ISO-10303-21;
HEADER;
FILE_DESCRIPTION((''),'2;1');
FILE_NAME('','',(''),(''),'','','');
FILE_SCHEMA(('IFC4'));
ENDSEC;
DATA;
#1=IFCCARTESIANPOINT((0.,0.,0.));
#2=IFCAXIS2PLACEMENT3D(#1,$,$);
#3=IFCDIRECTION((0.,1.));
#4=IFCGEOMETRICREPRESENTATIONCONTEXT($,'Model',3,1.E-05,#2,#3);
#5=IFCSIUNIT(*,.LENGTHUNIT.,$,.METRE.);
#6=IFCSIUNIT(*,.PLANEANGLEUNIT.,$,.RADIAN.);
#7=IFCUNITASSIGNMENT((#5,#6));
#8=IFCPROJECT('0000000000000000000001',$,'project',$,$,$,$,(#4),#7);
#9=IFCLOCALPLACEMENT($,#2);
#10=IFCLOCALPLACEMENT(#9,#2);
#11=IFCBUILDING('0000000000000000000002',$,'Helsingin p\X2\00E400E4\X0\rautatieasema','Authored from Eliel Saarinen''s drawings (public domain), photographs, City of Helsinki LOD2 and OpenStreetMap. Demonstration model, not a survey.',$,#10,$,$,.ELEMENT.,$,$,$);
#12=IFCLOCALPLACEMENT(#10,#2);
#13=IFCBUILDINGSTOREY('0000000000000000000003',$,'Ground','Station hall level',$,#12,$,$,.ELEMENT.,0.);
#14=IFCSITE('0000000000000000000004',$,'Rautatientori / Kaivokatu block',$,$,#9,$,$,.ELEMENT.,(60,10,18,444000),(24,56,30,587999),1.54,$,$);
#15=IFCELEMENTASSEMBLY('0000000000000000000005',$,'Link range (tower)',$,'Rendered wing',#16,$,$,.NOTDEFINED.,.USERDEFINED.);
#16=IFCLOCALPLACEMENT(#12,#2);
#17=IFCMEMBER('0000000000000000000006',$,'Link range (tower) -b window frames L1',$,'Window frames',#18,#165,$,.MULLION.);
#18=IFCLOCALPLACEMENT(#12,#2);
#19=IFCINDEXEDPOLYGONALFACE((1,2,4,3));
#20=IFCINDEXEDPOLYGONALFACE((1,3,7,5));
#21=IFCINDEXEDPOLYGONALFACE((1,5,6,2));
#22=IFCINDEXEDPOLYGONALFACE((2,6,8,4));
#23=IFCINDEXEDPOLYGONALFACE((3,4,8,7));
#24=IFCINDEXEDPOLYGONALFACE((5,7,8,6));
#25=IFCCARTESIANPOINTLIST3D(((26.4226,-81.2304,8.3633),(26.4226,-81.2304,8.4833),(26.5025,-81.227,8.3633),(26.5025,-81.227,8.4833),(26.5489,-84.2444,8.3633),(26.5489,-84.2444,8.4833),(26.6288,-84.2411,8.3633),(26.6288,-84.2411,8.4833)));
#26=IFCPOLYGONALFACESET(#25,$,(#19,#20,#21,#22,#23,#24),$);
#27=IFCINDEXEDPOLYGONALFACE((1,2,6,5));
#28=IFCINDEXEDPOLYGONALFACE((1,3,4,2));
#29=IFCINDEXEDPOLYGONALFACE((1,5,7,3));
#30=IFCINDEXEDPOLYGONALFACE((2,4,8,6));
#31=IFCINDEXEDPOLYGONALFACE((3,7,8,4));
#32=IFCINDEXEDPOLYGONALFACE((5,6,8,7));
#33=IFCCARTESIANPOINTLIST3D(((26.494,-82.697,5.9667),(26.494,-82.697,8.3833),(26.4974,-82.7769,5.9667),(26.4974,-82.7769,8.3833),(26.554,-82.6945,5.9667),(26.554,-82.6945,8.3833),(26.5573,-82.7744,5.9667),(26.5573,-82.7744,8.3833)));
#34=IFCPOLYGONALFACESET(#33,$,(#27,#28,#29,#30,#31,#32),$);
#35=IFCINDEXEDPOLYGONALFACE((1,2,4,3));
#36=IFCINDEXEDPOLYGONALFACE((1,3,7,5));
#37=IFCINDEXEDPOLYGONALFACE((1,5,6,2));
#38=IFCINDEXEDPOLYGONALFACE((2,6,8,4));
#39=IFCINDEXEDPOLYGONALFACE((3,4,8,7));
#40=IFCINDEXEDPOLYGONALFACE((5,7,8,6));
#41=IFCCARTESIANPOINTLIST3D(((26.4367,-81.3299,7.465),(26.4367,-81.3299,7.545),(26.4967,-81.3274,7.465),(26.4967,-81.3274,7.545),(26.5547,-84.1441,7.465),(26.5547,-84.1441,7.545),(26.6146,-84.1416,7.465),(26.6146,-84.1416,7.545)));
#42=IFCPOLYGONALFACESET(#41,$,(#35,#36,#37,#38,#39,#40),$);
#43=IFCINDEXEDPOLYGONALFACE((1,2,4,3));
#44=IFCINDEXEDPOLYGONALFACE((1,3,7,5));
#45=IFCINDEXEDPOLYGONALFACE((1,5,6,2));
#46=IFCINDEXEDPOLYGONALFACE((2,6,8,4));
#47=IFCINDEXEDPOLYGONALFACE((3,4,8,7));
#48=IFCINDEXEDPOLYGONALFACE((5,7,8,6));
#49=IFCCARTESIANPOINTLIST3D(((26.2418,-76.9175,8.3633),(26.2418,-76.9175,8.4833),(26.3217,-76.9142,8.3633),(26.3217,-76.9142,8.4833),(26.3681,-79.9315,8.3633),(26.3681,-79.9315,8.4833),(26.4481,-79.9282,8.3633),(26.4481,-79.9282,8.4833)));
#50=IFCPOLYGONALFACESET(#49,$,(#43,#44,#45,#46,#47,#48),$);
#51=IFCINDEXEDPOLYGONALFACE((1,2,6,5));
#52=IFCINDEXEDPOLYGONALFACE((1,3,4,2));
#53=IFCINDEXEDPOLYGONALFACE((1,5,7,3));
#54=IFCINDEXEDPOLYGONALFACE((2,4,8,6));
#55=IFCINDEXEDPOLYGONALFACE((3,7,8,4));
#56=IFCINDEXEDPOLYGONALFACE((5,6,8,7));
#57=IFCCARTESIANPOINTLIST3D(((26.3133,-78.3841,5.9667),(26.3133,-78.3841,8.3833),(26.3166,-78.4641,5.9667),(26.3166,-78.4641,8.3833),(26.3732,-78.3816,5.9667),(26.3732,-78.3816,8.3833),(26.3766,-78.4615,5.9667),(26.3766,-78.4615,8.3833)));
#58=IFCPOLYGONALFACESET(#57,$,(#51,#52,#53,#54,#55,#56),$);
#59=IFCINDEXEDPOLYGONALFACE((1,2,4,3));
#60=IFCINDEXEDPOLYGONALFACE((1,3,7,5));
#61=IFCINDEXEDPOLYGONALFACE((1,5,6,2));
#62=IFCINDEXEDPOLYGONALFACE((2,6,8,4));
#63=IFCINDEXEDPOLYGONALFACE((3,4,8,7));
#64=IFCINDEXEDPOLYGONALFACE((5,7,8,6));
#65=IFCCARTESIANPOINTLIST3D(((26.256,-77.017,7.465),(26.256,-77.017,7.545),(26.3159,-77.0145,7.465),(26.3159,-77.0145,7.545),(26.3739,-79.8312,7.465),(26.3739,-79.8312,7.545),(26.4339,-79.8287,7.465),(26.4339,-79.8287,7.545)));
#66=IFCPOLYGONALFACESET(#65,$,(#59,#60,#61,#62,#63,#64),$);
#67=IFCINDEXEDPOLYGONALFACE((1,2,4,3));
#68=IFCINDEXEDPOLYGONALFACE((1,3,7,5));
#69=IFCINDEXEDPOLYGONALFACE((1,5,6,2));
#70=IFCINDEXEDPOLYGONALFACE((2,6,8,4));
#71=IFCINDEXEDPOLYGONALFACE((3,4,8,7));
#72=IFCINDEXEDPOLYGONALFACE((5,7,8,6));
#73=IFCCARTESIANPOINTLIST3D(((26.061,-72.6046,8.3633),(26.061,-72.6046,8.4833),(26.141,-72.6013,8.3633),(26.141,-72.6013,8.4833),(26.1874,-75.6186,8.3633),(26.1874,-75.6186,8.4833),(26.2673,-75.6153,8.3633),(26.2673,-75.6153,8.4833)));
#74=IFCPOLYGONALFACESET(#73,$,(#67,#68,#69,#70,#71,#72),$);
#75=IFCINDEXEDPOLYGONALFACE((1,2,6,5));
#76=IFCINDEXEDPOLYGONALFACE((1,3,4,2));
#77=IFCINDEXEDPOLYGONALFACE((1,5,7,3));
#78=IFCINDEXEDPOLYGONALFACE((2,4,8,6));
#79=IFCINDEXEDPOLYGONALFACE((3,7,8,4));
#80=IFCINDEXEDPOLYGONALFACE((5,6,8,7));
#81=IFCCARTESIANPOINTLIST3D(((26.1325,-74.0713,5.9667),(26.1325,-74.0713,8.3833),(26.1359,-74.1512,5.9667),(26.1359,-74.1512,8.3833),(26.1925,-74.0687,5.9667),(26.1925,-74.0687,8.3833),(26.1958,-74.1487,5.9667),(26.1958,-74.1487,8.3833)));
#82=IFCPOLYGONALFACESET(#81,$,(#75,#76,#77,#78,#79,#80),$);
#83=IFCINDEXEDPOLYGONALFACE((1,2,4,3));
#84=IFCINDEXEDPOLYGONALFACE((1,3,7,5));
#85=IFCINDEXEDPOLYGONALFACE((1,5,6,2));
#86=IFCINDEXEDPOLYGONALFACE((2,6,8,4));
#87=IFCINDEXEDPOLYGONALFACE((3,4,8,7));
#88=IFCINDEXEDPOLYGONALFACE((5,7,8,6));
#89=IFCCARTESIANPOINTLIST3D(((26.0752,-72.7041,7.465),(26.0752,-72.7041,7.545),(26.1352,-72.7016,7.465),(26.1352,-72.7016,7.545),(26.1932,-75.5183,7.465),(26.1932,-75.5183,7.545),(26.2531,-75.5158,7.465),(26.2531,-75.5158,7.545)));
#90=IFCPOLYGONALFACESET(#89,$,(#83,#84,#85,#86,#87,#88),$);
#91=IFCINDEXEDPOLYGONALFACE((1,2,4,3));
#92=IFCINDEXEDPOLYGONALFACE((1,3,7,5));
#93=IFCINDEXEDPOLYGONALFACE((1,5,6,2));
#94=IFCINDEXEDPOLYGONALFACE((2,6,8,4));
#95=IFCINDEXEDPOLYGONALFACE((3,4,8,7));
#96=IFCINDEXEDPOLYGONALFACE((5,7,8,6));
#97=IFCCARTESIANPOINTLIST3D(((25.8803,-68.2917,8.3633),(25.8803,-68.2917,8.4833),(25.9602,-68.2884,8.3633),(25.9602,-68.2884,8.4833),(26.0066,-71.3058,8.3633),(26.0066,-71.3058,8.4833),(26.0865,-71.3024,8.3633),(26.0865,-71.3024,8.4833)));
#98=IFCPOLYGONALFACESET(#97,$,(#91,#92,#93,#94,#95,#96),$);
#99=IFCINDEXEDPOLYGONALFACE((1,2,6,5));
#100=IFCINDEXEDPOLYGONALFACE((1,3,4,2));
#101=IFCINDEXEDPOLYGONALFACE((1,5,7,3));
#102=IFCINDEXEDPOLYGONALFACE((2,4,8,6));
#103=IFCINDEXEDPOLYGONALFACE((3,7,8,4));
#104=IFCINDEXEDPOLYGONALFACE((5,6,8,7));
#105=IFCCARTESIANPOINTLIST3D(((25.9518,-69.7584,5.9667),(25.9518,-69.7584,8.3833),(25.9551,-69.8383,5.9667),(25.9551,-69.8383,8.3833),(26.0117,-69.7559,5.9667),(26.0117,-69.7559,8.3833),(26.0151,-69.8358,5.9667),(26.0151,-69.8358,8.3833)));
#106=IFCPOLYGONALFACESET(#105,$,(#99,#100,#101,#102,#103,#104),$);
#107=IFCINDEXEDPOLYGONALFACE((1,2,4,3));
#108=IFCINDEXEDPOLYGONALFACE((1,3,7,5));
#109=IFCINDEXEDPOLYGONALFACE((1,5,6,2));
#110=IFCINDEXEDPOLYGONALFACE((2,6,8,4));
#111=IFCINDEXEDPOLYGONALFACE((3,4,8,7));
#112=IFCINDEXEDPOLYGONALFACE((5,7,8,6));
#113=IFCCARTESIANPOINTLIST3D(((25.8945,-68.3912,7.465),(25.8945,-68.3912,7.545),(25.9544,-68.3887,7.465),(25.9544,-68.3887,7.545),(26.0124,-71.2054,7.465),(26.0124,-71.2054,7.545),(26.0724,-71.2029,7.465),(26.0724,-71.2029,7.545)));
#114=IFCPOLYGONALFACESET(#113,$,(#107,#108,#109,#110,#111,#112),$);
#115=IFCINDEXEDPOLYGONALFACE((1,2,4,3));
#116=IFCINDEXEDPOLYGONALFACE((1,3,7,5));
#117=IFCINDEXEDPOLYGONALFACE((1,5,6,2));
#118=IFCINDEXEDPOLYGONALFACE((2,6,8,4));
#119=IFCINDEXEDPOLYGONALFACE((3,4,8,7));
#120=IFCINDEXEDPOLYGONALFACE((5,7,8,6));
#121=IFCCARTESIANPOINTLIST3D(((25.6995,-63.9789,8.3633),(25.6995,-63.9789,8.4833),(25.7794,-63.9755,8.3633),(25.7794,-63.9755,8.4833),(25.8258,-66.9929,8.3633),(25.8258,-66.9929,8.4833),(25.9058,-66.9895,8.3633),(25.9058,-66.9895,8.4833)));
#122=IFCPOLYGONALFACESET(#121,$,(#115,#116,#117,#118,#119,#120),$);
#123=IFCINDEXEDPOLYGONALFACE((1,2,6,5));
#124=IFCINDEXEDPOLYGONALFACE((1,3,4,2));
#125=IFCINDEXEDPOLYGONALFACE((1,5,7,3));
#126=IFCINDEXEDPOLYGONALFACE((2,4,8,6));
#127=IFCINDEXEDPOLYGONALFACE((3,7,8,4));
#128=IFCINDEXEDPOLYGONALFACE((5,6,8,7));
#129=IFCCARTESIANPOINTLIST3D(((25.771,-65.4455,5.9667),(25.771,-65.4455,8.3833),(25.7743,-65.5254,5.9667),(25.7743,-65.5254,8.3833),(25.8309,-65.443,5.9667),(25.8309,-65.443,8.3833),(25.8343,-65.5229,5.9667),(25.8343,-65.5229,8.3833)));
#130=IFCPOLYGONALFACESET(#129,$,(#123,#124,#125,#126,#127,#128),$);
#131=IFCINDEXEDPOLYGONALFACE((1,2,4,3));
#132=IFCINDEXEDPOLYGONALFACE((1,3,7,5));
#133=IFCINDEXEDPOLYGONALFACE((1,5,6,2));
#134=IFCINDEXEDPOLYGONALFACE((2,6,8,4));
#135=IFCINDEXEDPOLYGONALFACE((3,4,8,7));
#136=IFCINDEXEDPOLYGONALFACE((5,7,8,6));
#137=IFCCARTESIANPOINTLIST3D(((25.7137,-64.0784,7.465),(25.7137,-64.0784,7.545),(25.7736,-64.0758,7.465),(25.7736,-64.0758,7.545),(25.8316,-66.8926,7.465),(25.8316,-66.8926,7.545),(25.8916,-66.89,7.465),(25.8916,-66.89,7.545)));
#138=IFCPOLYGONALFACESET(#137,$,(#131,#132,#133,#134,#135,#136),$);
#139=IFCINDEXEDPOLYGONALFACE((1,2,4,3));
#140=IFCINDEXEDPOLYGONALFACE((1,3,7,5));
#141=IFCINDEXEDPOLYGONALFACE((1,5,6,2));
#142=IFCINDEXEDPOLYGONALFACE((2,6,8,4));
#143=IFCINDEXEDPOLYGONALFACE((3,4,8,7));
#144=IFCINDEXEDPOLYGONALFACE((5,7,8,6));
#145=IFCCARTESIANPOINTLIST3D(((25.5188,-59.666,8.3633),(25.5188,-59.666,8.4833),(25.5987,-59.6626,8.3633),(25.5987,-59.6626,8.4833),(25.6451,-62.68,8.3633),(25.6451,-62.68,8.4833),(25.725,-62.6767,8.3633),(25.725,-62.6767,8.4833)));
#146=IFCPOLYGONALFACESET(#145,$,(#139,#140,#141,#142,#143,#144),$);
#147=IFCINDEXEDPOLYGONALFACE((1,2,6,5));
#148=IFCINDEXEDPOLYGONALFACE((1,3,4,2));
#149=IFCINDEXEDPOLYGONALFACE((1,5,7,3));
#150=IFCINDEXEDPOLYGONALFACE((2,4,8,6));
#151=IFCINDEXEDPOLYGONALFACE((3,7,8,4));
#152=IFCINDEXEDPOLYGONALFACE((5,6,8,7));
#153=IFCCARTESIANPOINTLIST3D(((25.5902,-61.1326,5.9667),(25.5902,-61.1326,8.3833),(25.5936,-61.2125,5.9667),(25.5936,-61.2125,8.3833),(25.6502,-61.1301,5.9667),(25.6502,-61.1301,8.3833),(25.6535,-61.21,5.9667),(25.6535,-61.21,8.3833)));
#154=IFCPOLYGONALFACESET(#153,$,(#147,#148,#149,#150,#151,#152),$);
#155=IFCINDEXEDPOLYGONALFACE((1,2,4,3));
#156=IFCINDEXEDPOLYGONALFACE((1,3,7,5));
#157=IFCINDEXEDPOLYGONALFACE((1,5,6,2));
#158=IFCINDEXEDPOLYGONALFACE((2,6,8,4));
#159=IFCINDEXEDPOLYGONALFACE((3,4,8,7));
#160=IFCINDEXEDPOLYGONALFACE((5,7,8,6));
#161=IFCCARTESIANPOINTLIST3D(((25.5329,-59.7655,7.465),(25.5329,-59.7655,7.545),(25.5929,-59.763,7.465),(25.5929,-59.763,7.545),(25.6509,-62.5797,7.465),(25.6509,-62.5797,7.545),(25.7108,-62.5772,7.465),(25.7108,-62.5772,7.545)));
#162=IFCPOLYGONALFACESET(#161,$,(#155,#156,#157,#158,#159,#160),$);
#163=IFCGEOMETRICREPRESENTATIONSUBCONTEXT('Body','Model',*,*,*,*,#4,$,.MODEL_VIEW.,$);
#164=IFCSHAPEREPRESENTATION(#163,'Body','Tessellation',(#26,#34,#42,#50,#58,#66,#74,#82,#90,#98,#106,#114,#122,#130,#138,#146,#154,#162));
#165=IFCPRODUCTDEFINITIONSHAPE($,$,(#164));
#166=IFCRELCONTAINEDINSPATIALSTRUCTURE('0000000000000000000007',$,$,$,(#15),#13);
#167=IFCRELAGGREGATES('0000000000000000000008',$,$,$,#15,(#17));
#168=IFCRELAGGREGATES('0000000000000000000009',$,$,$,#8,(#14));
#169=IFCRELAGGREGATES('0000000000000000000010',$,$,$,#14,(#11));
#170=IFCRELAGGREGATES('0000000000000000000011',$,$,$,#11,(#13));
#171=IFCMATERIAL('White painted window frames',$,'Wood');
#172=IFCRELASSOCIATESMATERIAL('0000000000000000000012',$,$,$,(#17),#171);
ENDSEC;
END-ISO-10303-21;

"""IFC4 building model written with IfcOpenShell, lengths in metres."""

from ifc_helpers import new_model, si_unit, direction, frame, frame_2d, origin, place, context, subcontext, project, spatial, rectangle, extrude, material, element, aggregate, save


model = new_model("IFC4")

# Units and contexts
model_context = context("Model", 3, precision=1e-05, world=origin(), true_north=direction((0.0, 1.0)))
body_context = subcontext(model_context, "Body", "Model", "MODEL_VIEW")
ifc_project = project(units=[si_unit("LENGTHUNIT", "METRE"), si_unit("PLANEANGLEUNIT", "RADIAN")], contexts=[model_context])

# Site, building, storey
site_placement = place(None, origin())
site = spatial("IfcSite", under=ifc_project, at=site_placement, Name="Rautatientori / Kaivokatu block", CompositionType="ELEMENT", RefLatitude=(60, 10, 18, 444000), RefLongitude=(24, 56, 30, 587999), RefElevation=1.54)
building_placement = place(site_placement, origin())
building = spatial("IfcBuilding", under=site, at=building_placement, Name="Helsingin päärautatieasema", Description="Authored from Eliel Saarinen's drawings (public domain), photographs, City of Helsinki LOD2 and OpenStreetMap. Demonstration model, not a survey.", CompositionType="ELEMENT")
storey_placement = place(building_placement, origin())
storey = spatial("IfcBuildingStorey", under=building, at=storey_placement, Name="Ground", Description="Station hall level", CompositionType="ELEMENT", Elevation=0.0)

# Shared definitions
ifc_material_1 = material(Name="White painted window frames", Category="Wood")

# Element assembly, member
assembly_1_placement = place(building_placement, origin())
assembly_1 = element("IfcElementAssembly", 1, at=assembly_1_placement, inside=storey, Name="Link range (tower)", ObjectType="Rendered wing", AssemblyPlace="NOTDEFINED", PredefinedType="USERDEFINED")
member_1_placement = place(building_placement, origin())
member_1 = element("IfcMember", 2, at=member_1_placement, material=ifc_material_1, Name="Link range (tower) -b window frames L1", ObjectType="Window frames", PredefinedType="MULLION", context=body_context, shape_type="SweptSolid", body=[
    extrude(rectangle(XDim=3.0167, YDim=0.08, at=frame_2d((0.0, 0.0), x_axis=(-0.041876, 0.999123))), frame((26.5257, -82.7357, 8.3633)), (0.0, 0.0, 1.0), 0.12),
    extrude(rectangle(XDim=0.08, YDim=0.06, at=frame_2d((0.0, 0.0), x_axis=(-0.041876, 0.999123))), frame((26.5257, -82.7357, 5.9667)), (0.0, 0.0, 1.0), 2.4167),
    extrude(rectangle(XDim=2.8167, YDim=0.06, at=frame_2d((0.0, 0.0), x_axis=(-0.041876, 0.999123))), frame((26.5257, -82.7357, 7.465)), (0.0, 0.0, 1.0), 0.08),
    extrude(rectangle(XDim=3.0167, YDim=0.08, at=frame_2d((0.0, 0.0), x_axis=(-0.041876, 0.999123))), frame((26.3449, -78.4228, 8.3633)), (0.0, 0.0, 1.0), 0.12),
    extrude(rectangle(XDim=0.08, YDim=0.06, at=frame_2d((0.0, 0.0), x_axis=(-0.041876, 0.999123))), frame((26.3449, -78.4228, 5.9667)), (0.0, 0.0, 1.0), 2.4167),
    extrude(rectangle(XDim=2.8167, YDim=0.06, at=frame_2d((0.0, 0.0), x_axis=(-0.041876, 0.999123))), frame((26.3449, -78.4228, 7.465)), (0.0, 0.0, 1.0), 0.08),
    extrude(rectangle(XDim=3.0167, YDim=0.08, at=frame_2d((0.0, 0.0), x_axis=(-0.041876, 0.999123))), frame((26.1642, -74.11, 8.3633)), (0.0, 0.0, 1.0), 0.12),
    extrude(rectangle(XDim=0.08, YDim=0.06, at=frame_2d((0.0, 0.0), x_axis=(-0.041876, 0.999123))), frame((26.1642, -74.11, 5.9667)), (0.0, 0.0, 1.0), 2.4167),
    extrude(rectangle(XDim=2.8167, YDim=0.06, at=frame_2d((0.0, 0.0), x_axis=(-0.041876, 0.999123))), frame((26.1642, -74.11, 7.465)), (0.0, 0.0, 1.0), 0.08),
    extrude(rectangle(XDim=3.0167, YDim=0.08, at=frame_2d((0.0, 0.0), x_axis=(-0.041876, 0.999123))), frame((25.9834, -69.7971, 8.3633)), (0.0, 0.0, 1.0), 0.12),
    extrude(rectangle(XDim=0.08, YDim=0.06, at=frame_2d((0.0, 0.0), x_axis=(-0.041876, 0.999123))), frame((25.9834, -69.7971, 5.9667)), (0.0, 0.0, 1.0), 2.4167),
    extrude(rectangle(XDim=2.8167, YDim=0.06, at=frame_2d((0.0, 0.0), x_axis=(-0.041876, 0.999123))), frame((25.9834, -69.7971, 7.465)), (0.0, 0.0, 1.0), 0.08),
    extrude(rectangle(XDim=3.0167, YDim=0.08, at=frame_2d((0.0, 0.0), x_axis=(-0.041876, 0.999123))), frame((25.8026, -65.4842, 8.3633)), (0.0, 0.0, 1.0), 0.12),
    extrude(rectangle(XDim=0.08, YDim=0.06, at=frame_2d((0.0, 0.0), x_axis=(-0.041876, 0.999123))), frame((25.8026, -65.4842, 5.9667)), (0.0, 0.0, 1.0), 2.4167),
    extrude(rectangle(XDim=2.8167, YDim=0.06, at=frame_2d((0.0, 0.0), x_axis=(-0.041876, 0.999123))), frame((25.8026, -65.4842, 7.465)), (0.0, 0.0, 1.0), 0.08),
    extrude(rectangle(XDim=3.0167, YDim=0.08, at=frame_2d((0.0, 0.0), x_axis=(-0.041876, 0.999123))), frame((25.6219, -61.1713, 8.3633)), (0.0, 0.0, 1.0), 0.12),
    extrude(rectangle(XDim=0.08, YDim=0.06, at=frame_2d((0.0, 0.0), x_axis=(-0.041876, 0.999123))), frame((25.6219, -61.1713, 5.9667)), (0.0, 0.0, 1.0), 2.4167),
    extrude(rectangle(XDim=2.8167, YDim=0.06, at=frame_2d((0.0, 0.0), x_axis=(-0.041876, 0.999123))), frame((25.6219, -61.1713, 7.465)), (0.0, 0.0, 1.0), 0.08),
])

aggregate(assembly_1, [member_1])

save(model, "model.ifc")
